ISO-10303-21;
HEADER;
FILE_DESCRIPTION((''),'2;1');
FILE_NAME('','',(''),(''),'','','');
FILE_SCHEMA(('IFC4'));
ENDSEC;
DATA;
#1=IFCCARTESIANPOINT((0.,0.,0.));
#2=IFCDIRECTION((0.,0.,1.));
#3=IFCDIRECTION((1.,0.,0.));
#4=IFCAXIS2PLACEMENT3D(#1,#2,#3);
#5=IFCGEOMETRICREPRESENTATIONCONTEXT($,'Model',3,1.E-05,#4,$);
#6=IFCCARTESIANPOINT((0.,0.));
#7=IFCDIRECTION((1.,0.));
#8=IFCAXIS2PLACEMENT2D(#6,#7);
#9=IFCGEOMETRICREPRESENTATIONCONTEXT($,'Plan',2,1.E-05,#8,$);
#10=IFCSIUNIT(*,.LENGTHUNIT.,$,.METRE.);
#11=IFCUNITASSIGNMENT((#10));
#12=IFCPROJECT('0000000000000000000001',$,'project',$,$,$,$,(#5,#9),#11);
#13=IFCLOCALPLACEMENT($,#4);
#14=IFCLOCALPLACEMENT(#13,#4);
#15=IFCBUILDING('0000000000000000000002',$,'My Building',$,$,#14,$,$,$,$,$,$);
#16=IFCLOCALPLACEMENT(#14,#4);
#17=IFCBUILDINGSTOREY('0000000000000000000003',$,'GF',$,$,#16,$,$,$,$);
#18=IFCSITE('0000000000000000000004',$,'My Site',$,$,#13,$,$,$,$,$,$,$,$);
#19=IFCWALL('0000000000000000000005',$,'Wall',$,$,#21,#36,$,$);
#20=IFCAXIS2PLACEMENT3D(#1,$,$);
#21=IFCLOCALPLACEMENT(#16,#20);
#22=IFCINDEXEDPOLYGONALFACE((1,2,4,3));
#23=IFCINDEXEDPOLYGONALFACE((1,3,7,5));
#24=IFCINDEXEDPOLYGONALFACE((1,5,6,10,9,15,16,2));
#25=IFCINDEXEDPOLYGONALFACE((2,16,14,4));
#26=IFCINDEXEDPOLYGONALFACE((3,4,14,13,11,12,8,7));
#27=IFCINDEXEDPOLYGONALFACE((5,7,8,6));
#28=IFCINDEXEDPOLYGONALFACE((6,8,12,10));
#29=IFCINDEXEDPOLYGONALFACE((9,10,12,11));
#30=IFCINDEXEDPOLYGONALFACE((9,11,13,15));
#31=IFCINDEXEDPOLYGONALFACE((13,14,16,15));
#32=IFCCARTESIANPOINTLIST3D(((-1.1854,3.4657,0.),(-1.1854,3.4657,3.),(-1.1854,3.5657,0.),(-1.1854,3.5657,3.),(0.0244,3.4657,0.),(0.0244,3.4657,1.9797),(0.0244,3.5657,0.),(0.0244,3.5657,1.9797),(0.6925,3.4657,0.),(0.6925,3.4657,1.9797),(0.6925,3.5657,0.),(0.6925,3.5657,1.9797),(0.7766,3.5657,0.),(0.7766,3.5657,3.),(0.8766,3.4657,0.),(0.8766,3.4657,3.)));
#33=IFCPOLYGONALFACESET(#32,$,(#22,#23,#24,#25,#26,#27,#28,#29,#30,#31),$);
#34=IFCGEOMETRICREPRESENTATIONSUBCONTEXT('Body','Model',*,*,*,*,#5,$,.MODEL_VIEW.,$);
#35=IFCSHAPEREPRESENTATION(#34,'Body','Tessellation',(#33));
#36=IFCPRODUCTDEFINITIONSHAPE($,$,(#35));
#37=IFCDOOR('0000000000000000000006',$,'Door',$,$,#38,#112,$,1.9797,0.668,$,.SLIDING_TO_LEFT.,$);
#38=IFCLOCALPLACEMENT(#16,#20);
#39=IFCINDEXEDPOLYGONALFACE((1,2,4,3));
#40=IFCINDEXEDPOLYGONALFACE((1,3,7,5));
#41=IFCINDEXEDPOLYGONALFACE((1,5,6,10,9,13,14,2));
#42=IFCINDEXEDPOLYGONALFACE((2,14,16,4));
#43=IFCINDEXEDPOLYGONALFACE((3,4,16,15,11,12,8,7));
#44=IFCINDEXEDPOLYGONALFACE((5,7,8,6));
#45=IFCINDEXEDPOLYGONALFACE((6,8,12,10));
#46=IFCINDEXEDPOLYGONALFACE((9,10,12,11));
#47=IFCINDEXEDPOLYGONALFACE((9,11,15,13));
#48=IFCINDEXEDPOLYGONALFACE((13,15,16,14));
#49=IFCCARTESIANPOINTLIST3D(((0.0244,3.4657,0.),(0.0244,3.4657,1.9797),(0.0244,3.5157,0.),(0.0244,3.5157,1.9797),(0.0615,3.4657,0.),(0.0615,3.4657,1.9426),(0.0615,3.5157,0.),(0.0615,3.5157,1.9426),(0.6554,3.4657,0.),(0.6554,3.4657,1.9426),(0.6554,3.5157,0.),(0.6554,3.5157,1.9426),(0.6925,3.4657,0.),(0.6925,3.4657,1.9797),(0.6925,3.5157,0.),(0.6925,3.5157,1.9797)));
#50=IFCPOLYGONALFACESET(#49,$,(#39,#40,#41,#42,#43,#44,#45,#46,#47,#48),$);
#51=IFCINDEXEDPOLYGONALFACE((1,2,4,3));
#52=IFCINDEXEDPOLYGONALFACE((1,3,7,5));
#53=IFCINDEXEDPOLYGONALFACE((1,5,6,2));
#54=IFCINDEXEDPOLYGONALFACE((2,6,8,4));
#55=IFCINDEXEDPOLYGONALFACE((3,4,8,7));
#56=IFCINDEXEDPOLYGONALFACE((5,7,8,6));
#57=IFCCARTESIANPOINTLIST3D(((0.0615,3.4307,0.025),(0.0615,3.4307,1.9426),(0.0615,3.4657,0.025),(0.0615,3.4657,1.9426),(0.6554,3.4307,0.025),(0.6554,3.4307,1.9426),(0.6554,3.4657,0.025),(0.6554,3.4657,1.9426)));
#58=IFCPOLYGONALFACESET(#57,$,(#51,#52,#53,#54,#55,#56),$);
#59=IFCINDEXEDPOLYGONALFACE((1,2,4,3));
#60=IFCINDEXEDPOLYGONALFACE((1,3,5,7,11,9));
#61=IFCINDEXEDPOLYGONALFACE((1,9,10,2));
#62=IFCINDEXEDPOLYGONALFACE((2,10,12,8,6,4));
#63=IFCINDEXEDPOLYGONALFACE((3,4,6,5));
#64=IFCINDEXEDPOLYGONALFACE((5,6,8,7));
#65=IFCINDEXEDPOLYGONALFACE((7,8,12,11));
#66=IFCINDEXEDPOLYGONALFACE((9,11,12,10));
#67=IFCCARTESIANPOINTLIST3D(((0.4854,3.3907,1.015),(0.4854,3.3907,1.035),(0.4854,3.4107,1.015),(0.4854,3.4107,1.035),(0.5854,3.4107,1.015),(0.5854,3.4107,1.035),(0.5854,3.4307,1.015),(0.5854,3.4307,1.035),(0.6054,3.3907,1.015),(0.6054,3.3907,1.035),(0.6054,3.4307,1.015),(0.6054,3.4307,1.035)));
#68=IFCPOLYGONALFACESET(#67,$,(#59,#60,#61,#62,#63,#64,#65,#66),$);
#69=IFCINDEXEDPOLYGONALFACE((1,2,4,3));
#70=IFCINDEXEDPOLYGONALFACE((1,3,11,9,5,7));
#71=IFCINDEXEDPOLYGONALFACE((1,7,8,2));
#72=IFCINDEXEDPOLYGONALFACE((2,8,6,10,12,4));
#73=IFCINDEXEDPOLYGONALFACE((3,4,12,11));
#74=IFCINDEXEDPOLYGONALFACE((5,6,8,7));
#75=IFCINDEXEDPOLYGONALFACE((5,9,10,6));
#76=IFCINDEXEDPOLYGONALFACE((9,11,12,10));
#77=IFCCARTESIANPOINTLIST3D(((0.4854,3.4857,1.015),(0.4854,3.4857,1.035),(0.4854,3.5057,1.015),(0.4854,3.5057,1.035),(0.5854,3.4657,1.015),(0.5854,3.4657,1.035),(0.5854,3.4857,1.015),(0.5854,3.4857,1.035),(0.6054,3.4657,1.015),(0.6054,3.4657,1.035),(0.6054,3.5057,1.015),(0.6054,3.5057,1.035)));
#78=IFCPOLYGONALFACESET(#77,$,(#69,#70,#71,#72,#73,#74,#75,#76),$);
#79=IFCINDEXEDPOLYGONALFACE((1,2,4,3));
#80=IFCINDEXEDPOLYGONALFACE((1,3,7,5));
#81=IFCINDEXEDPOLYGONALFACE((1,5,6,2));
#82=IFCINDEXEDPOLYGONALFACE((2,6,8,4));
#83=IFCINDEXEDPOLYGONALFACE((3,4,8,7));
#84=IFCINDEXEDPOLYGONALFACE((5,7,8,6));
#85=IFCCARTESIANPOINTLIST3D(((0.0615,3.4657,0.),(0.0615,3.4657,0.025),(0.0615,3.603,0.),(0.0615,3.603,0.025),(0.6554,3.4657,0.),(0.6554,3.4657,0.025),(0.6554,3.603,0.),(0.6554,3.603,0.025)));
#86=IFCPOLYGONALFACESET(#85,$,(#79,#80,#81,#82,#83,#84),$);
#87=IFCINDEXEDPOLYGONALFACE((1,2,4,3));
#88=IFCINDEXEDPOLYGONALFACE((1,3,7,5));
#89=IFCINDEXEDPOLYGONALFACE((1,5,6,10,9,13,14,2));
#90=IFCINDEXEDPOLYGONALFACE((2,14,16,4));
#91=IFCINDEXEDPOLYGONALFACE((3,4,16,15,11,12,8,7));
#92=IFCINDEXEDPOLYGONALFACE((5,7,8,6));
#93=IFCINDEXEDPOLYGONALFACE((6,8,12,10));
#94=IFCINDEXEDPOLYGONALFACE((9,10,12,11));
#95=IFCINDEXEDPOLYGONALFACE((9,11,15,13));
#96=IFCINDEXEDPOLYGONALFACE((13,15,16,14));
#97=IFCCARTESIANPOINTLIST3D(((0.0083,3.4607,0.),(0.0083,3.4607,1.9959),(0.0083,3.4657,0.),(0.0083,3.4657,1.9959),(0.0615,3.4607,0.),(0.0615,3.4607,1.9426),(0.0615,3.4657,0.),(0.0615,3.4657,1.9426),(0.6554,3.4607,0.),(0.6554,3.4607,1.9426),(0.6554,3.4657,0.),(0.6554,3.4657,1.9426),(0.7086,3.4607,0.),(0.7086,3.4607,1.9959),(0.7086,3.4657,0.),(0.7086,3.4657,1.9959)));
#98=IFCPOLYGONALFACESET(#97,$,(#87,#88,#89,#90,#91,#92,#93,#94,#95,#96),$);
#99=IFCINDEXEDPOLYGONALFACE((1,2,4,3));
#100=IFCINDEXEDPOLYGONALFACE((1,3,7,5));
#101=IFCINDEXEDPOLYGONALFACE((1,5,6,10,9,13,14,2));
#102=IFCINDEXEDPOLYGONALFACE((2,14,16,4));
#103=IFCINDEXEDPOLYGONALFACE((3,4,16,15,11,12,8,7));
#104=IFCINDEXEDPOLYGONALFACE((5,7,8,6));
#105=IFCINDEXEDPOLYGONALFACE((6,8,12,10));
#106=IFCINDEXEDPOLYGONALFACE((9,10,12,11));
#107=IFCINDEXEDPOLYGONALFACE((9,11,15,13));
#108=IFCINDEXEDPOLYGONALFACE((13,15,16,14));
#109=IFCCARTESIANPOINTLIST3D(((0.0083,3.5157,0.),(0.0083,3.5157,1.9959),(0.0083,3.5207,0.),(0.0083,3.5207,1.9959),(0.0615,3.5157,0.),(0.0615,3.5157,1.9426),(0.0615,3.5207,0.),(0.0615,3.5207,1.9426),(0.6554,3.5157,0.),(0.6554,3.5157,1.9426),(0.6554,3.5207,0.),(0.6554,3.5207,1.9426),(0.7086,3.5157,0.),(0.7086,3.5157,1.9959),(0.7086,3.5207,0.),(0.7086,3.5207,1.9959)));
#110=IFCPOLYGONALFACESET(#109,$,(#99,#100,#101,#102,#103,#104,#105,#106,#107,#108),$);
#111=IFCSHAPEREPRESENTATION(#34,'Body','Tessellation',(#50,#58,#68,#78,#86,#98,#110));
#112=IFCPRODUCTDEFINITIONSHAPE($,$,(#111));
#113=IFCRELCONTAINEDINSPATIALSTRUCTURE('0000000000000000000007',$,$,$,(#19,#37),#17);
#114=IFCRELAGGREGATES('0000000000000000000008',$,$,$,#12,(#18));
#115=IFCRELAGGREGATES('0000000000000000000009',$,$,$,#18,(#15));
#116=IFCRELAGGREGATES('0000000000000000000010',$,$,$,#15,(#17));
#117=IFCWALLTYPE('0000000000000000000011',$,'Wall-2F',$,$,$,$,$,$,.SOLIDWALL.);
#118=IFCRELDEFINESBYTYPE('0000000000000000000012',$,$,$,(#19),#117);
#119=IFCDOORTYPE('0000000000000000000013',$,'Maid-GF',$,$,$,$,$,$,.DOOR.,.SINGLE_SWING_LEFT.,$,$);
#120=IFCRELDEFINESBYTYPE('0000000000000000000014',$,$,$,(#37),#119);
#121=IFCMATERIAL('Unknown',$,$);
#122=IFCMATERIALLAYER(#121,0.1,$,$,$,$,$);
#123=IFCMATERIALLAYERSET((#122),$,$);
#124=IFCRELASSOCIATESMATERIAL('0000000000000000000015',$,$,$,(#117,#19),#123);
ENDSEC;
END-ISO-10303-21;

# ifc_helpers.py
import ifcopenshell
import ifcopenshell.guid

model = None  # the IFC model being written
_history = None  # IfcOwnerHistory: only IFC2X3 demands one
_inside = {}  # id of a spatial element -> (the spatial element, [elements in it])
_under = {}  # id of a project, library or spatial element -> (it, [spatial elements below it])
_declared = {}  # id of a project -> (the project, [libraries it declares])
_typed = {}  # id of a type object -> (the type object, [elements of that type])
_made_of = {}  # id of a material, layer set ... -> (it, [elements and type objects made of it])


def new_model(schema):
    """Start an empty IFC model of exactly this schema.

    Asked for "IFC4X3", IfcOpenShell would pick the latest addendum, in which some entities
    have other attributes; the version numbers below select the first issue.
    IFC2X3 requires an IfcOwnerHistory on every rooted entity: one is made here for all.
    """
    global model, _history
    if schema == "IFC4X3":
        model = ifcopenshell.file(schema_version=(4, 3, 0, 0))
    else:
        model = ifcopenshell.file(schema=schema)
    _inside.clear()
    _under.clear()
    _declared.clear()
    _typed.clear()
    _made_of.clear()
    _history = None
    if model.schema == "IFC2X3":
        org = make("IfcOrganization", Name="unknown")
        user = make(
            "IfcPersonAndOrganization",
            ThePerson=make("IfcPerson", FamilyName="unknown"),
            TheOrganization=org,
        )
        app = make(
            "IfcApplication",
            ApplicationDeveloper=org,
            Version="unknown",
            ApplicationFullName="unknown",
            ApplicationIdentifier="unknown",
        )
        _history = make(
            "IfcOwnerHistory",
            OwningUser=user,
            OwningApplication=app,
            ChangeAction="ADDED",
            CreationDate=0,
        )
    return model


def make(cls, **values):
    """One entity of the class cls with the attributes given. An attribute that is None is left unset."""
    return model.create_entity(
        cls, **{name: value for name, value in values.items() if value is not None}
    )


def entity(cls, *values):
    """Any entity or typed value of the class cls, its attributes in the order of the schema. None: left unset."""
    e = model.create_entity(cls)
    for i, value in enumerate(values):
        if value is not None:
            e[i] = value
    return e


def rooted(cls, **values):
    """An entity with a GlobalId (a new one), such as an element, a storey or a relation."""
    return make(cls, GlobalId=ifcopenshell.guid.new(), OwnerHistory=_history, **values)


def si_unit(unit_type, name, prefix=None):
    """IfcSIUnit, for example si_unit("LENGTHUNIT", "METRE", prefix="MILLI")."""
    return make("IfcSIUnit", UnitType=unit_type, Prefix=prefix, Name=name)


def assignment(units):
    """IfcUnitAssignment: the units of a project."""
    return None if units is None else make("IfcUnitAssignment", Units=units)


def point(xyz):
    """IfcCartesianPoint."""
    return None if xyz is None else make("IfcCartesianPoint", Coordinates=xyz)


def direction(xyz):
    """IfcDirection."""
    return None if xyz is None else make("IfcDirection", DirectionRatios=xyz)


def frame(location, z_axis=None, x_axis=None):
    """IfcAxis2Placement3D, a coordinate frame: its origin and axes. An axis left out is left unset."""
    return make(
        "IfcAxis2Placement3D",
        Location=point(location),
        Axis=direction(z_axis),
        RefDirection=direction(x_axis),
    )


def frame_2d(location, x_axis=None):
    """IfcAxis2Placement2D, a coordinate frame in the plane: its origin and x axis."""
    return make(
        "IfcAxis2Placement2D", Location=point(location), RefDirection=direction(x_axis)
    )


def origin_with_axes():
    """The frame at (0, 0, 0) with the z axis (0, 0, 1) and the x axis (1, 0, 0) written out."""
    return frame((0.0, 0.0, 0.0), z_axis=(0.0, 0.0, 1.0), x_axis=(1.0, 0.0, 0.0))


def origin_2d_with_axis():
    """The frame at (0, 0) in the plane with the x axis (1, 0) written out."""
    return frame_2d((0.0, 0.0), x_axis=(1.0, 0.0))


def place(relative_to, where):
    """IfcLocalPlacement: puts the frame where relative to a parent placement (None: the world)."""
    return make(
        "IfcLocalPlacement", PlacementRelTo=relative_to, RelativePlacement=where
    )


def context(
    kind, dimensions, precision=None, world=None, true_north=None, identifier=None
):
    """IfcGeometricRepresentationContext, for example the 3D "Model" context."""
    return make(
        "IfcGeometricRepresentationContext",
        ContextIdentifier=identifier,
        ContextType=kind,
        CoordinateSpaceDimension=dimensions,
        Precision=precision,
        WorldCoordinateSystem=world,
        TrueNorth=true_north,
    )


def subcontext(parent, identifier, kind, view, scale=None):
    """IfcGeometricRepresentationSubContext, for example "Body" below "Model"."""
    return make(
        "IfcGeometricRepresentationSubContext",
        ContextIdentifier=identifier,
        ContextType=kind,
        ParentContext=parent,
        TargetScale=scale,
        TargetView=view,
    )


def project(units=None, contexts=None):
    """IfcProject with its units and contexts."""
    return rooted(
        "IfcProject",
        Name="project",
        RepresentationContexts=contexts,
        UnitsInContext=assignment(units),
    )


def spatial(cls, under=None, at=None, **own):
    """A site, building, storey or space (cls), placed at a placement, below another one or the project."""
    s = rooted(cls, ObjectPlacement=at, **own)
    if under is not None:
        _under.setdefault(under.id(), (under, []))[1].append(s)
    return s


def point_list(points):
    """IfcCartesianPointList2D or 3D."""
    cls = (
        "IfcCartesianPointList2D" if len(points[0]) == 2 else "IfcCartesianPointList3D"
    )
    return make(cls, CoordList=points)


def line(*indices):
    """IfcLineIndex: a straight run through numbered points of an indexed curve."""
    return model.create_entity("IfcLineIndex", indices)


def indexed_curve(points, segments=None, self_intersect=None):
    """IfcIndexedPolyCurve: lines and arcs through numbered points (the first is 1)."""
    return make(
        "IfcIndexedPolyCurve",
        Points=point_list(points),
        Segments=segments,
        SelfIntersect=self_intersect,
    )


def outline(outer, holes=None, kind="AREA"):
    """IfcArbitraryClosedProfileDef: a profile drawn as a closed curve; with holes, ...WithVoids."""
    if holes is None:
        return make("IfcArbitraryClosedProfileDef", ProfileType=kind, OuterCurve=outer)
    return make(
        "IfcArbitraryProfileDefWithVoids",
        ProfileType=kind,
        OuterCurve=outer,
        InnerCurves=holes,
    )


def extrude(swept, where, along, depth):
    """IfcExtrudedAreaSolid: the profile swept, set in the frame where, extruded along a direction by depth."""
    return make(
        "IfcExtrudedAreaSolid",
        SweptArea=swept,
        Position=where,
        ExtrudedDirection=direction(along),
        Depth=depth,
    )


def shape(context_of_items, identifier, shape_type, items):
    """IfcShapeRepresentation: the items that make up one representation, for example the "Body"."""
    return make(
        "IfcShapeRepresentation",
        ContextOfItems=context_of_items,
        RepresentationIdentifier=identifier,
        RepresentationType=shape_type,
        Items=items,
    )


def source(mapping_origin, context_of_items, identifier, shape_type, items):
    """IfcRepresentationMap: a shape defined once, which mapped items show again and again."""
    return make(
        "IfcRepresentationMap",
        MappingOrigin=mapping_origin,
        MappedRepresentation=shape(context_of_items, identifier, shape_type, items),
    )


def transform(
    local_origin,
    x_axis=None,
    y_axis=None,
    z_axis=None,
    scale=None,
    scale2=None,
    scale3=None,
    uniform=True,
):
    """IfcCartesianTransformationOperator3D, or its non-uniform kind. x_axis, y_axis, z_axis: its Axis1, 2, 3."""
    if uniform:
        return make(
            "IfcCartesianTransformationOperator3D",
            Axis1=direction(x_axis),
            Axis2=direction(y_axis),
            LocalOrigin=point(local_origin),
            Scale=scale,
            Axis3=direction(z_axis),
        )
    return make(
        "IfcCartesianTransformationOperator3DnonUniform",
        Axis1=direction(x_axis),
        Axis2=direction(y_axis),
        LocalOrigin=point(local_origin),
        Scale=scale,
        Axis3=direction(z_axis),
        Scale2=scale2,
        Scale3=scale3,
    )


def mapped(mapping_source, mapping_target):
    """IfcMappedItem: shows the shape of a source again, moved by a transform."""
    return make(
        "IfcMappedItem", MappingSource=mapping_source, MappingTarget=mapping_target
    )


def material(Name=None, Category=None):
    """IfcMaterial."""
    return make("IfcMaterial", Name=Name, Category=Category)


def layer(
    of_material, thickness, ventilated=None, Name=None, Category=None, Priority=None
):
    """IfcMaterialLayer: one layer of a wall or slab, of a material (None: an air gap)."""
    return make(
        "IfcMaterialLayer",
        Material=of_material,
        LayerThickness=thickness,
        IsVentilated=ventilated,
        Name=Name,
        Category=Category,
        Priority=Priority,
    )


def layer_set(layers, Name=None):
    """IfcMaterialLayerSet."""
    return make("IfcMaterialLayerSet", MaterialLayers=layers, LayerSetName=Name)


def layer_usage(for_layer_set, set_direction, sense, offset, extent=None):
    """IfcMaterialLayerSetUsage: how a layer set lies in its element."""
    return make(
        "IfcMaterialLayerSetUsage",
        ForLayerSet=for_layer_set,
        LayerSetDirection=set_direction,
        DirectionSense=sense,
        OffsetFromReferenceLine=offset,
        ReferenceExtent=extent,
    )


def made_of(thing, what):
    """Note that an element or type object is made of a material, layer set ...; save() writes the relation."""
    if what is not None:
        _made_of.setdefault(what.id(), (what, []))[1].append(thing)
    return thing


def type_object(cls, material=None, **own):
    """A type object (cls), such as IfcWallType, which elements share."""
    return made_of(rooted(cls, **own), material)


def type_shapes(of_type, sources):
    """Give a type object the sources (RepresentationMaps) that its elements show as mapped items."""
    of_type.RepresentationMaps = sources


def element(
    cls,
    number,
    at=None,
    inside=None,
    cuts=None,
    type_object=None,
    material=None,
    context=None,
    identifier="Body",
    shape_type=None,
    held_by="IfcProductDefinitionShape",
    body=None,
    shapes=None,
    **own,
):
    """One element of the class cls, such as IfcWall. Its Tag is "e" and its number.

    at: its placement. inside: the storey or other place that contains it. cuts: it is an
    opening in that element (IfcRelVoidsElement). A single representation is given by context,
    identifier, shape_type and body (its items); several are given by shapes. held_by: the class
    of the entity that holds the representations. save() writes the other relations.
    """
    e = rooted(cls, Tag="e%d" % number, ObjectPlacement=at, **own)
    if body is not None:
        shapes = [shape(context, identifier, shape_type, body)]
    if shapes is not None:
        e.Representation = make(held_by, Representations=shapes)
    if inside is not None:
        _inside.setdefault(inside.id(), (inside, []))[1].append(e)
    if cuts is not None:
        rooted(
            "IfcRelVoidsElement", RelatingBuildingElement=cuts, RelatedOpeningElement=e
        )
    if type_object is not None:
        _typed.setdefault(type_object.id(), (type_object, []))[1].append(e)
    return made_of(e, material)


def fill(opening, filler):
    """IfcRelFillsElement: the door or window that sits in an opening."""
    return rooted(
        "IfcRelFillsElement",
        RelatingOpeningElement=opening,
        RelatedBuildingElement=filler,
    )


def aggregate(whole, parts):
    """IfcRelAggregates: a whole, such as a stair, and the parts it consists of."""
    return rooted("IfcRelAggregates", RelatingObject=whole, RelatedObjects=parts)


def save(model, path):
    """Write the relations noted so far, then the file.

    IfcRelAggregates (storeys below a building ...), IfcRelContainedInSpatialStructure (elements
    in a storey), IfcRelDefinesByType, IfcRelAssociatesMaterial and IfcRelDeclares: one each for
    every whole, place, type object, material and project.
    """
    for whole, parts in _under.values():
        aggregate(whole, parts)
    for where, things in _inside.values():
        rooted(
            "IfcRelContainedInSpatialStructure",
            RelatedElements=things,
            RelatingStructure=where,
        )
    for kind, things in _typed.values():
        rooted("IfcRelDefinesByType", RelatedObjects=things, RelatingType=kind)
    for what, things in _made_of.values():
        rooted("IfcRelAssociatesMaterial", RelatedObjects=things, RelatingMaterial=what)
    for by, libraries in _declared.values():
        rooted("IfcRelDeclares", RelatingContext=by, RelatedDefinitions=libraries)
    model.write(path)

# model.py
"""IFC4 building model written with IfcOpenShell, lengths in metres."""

from ifc_helpers import new_model, entity, si_unit, frame, origin_with_axes, origin_2d_with_axis, place, context, subcontext, project, spatial, line, indexed_curve, outline, extrude, shape, source, transform, mapped, material, layer, layer_set, layer_usage, type_object, type_shapes, element, fill, save


model = new_model("IFC4")

# Units and contexts
model_context = context("Model", 3, precision=1e-05, world=origin_with_axes())
plan_context = context("Plan", 2, precision=1e-05, world=origin_2d_with_axis())
body_context_1 = subcontext(model_context, "Body", "Model", "MODEL_VIEW")
body_context_2 = subcontext(plan_context, "Body", "Plan", "PLAN_VIEW")
ifc_project = project(units=[si_unit("LENGTHUNIT", "METRE")], contexts=[model_context, plan_context])

# Site, building, storey
site_placement = place(None, origin_with_axes())
site = spatial("IfcSite", under=ifc_project, at=site_placement, Name="My Site")
building_placement = place(site_placement, origin_with_axes())
building = spatial("IfcBuilding", under=site, at=building_placement, Name="My Building")
storey_placement = place(building_placement, origin_with_axes())
storey = spatial("IfcBuildingStorey", under=building, at=storey_placement, Name="GF")

# Shared definitions
ifc_material = material(Name="Unknown")

# Shared definitions
ifc_layer_1 = layer(ifc_material, 0.1)
ifc_layer_set_1 = layer_set([ifc_layer_1])
wall_type = type_object("IfcWallType", Name="Wall-2F", PredefinedType="SOLIDWALL", material=ifc_layer_set_1)

# Wall, opening, door
ifc_layer_usage_1 = layer_usage(ifc_layer_set_1, "AXIS2", "POSITIVE", 0.0)
wall_1_placement = place(storey_placement, frame((0.7766, 3.5657, 0.0), z_axis=(0.0, 0.0, 1.0), x_axis=(-1.0, 0.0, 0.0)))
wall_1 = element("IfcWall", 1, at=wall_1_placement, inside=storey, type_object=wall_type, material=ifc_layer_usage_1, Name="Wall", context=body_context_1, shape_type="SweptSolid", body=[
    extrude(outline(indexed_curve([(0.0, 0.0), (-0.1, 0.1), (1.962, 0.1), (1.962, 0.0)], segments=[line(1, 2, 3, 4, 1)])), origin_with_axes(), (0.0, 0.0, 1.0), 3.0),
])
shared_shape_1 = source(origin_with_axes(), body_context_1, "Body", "SweptSolid", [
    extrude(outline(indexed_curve([(0.0, 0.0), (0.668, 0.0), (0.668, 1.9797), (0.0, 1.9797)], segments=[line(1, 2, 3, 4, 1)])), frame((0.0, -0.6, 0.0), z_axis=(0.0, -1.0, 0.0), x_axis=(1.0, 0.0, 0.0)), (0.0, 0.0, -1.0), 1.2),
])
opening_1_placement = place(wall_1_placement, frame((0.7522, 0.1, 0.0), z_axis=(0.0, 0.0, 1.0), x_axis=(-1.0, 0.0, 0.0)))
opening_1 = element("IfcOpeningElement", 2, at=opening_1_placement, cuts=wall_1, PredefinedType="OPENING", context=body_context_1, shape_type="MappedRepresentation", body=[
    mapped(shared_shape_1, transform((0.0, 0.0, 0.0), x_axis=(1.0, 0.0, 0.0), y_axis=(0.0, 1.0, 0.0), z_axis=(0.0, 0.0, 1.0), scale=1.0)),
])
door_type_1 = type_object("IfcDoorType", Name="Maid-GF", OperationType="SINGLE_SWING_LEFT", PredefinedType="DOOR")
shared_shape_2 = source(origin_with_axes(), body_context_1, "Body", "SweptSolid", [
    extrude(outline(indexed_curve([(0.0, 0.0), (0.0, 1.9797), (0.668, 1.9797), (0.668, 0.0), (0.6309, 0.0), (0.6309, 1.9426), (0.0371, 1.9426), (0.0371, 0.0)], segments=[line(1, 2, 3, 4, 5, 6, 7, 8, 1)])), frame((0.0, 0.0, 0.0), z_axis=(0.0, -1.0, 0.0), x_axis=(1.0, 0.0, 0.0)), (0.0, 0.0, -1.0), 0.05),
    extrude(outline(indexed_curve([(0.0, 0.0), (0.5938, 0.0), (0.5938, 0.035), (0.0, 0.035)], segments=[line(1, 2, 3, 4, 1)])), frame((0.0371, -0.035, 0.025), z_axis=(0.0, 0.0, 1.0), x_axis=(1.0, 0.0, 0.0)), (0.0, 0.0, 1.0), 1.9176),
    extrude(outline(indexed_curve([(0.0, 0.0), (0.0, -0.04), (-0.12, -0.04), (-0.12, -0.02), (-0.02, -0.02), (-0.02, 0.0)], segments=[line(1, 2, 3, 4, 5, 6, 1)])), frame((0.5809, -0.035, 1.015), z_axis=(0.0, 0.0, 1.0), x_axis=(1.0, 0.0, 0.0)), (0.0, 0.0, 1.0), 0.02),
    extrude(outline(indexed_curve([(0.0, 0.0), (0.0, 0.04), (-0.12, 0.04), (-0.12, 0.02), (-0.02, 0.02), (-0.02, 0.0)], segments=[line(1, 2, 3, 4, 5, 6, 1)])), frame((0.5809, 0.0, 1.015), z_axis=(0.0, 0.0, 1.0), x_axis=(1.0, 0.0, 0.0)), (0.0, 0.0, 1.0), 0.02),
    extrude(outline(indexed_curve([(0.0, 0.0), (0.5938, 0.0), (0.5938, 0.1372), (0.0, 0.1372)], segments=[line(1, 2, 3, 4, 1)])), frame((0.0371, 0.0, 0.0), z_axis=(0.0, 0.0, 1.0), x_axis=(1.0, 0.0, 0.0)), (0.0, 0.0, 1.0), 0.025),
    extrude(outline(indexed_curve([(0.0, 0.0), (0.0, 1.9959), (0.7003, 1.9959), (0.7003, 0.0), (0.6471, 0.0), (0.6471, 1.9426), (0.0532, 1.9426), (0.0532, 0.0)], segments=[line(1, 2, 3, 4, 5, 6, 7, 8, 1)])), frame((-0.0162, -0.005, 0.0), z_axis=(0.0, -1.0, 0.0), x_axis=(1.0, 0.0, 0.0)), (0.0, 0.0, -1.0), 0.005),
    extrude(outline(indexed_curve([(0.0, 0.0), (0.0, 1.9959), (0.7003, 1.9959), (0.7003, 0.0), (0.6471, 0.0), (0.6471, 1.9426), (0.0532, 1.9426), (0.0532, 0.0)], segments=[line(1, 2, 3, 4, 5, 6, 7, 8, 1)])), frame((-0.0162, 0.05, 0.0), z_axis=(0.0, -1.0, 0.0), x_axis=(1.0, 0.0, 0.0)), (0.0, 0.0, -1.0), 0.005),
])
shared_shape_3 = source(origin_with_axes(), body_context_2, "Body", "Curve2D", [
    entity("IfcIndexedPolyCurve", entity("IfcCartesianPointList2D", [[0.0, 0.0], [0.0371, 0.0], [0.0371, 0.05], [0.0, 0.05]]), [entity("IfcLineIndex", [1, 2, 3, 4, 1])]),
    entity("IfcIndexedPolyCurve", entity("IfcCartesianPointList2D", [[0.668, 0.0], [0.6309, 0.0], [0.6309, 0.05], [0.668, 0.05]]), [entity("IfcLineIndex", [1, 2, 3, 4, 1])]),
    entity("IfcIndexedPolyCurve", entity("IfcCartesianPointList2D", [[-0.2598, -0.035], [0.334, -0.035], [0.334, 0.0], [-0.2598, 0.0]]), [entity("IfcLineIndex", [1, 2, 3, 4, 1])]),
])
type_shapes(door_type_1, [shared_shape_2, shared_shape_3])
door_1_placement = place(opening_1_placement, origin_with_axes())
door_1 = element("IfcDoor", 3, at=door_1_placement, inside=storey, type_object=door_type_1, Name="Door", OperationType="SLIDING_TO_LEFT", OverallHeight=1.9797, OverallWidth=0.668, shapes=[
    shape(body_context_1, "Body", "MappedRepresentation", [mapped(shared_shape_2, transform((0.0, 0.0, 0.0), x_axis=(1.0, 0.0, 0.0), y_axis=(0.0, 1.0, 0.0), z_axis=(0.0, 0.0, 1.0), scale=1.0))]),
    shape(body_context_2, "Body", "MappedRepresentation", [mapped(shared_shape_3, transform((0.0, 0.0, 0.0), x_axis=(1.0, 0.0, 0.0), y_axis=(0.0, 1.0, 0.0), z_axis=(0.0, 0.0, 1.0), scale=1.0))]),
])
fill(opening_1, door_1)

save(model, "model.ifc")
